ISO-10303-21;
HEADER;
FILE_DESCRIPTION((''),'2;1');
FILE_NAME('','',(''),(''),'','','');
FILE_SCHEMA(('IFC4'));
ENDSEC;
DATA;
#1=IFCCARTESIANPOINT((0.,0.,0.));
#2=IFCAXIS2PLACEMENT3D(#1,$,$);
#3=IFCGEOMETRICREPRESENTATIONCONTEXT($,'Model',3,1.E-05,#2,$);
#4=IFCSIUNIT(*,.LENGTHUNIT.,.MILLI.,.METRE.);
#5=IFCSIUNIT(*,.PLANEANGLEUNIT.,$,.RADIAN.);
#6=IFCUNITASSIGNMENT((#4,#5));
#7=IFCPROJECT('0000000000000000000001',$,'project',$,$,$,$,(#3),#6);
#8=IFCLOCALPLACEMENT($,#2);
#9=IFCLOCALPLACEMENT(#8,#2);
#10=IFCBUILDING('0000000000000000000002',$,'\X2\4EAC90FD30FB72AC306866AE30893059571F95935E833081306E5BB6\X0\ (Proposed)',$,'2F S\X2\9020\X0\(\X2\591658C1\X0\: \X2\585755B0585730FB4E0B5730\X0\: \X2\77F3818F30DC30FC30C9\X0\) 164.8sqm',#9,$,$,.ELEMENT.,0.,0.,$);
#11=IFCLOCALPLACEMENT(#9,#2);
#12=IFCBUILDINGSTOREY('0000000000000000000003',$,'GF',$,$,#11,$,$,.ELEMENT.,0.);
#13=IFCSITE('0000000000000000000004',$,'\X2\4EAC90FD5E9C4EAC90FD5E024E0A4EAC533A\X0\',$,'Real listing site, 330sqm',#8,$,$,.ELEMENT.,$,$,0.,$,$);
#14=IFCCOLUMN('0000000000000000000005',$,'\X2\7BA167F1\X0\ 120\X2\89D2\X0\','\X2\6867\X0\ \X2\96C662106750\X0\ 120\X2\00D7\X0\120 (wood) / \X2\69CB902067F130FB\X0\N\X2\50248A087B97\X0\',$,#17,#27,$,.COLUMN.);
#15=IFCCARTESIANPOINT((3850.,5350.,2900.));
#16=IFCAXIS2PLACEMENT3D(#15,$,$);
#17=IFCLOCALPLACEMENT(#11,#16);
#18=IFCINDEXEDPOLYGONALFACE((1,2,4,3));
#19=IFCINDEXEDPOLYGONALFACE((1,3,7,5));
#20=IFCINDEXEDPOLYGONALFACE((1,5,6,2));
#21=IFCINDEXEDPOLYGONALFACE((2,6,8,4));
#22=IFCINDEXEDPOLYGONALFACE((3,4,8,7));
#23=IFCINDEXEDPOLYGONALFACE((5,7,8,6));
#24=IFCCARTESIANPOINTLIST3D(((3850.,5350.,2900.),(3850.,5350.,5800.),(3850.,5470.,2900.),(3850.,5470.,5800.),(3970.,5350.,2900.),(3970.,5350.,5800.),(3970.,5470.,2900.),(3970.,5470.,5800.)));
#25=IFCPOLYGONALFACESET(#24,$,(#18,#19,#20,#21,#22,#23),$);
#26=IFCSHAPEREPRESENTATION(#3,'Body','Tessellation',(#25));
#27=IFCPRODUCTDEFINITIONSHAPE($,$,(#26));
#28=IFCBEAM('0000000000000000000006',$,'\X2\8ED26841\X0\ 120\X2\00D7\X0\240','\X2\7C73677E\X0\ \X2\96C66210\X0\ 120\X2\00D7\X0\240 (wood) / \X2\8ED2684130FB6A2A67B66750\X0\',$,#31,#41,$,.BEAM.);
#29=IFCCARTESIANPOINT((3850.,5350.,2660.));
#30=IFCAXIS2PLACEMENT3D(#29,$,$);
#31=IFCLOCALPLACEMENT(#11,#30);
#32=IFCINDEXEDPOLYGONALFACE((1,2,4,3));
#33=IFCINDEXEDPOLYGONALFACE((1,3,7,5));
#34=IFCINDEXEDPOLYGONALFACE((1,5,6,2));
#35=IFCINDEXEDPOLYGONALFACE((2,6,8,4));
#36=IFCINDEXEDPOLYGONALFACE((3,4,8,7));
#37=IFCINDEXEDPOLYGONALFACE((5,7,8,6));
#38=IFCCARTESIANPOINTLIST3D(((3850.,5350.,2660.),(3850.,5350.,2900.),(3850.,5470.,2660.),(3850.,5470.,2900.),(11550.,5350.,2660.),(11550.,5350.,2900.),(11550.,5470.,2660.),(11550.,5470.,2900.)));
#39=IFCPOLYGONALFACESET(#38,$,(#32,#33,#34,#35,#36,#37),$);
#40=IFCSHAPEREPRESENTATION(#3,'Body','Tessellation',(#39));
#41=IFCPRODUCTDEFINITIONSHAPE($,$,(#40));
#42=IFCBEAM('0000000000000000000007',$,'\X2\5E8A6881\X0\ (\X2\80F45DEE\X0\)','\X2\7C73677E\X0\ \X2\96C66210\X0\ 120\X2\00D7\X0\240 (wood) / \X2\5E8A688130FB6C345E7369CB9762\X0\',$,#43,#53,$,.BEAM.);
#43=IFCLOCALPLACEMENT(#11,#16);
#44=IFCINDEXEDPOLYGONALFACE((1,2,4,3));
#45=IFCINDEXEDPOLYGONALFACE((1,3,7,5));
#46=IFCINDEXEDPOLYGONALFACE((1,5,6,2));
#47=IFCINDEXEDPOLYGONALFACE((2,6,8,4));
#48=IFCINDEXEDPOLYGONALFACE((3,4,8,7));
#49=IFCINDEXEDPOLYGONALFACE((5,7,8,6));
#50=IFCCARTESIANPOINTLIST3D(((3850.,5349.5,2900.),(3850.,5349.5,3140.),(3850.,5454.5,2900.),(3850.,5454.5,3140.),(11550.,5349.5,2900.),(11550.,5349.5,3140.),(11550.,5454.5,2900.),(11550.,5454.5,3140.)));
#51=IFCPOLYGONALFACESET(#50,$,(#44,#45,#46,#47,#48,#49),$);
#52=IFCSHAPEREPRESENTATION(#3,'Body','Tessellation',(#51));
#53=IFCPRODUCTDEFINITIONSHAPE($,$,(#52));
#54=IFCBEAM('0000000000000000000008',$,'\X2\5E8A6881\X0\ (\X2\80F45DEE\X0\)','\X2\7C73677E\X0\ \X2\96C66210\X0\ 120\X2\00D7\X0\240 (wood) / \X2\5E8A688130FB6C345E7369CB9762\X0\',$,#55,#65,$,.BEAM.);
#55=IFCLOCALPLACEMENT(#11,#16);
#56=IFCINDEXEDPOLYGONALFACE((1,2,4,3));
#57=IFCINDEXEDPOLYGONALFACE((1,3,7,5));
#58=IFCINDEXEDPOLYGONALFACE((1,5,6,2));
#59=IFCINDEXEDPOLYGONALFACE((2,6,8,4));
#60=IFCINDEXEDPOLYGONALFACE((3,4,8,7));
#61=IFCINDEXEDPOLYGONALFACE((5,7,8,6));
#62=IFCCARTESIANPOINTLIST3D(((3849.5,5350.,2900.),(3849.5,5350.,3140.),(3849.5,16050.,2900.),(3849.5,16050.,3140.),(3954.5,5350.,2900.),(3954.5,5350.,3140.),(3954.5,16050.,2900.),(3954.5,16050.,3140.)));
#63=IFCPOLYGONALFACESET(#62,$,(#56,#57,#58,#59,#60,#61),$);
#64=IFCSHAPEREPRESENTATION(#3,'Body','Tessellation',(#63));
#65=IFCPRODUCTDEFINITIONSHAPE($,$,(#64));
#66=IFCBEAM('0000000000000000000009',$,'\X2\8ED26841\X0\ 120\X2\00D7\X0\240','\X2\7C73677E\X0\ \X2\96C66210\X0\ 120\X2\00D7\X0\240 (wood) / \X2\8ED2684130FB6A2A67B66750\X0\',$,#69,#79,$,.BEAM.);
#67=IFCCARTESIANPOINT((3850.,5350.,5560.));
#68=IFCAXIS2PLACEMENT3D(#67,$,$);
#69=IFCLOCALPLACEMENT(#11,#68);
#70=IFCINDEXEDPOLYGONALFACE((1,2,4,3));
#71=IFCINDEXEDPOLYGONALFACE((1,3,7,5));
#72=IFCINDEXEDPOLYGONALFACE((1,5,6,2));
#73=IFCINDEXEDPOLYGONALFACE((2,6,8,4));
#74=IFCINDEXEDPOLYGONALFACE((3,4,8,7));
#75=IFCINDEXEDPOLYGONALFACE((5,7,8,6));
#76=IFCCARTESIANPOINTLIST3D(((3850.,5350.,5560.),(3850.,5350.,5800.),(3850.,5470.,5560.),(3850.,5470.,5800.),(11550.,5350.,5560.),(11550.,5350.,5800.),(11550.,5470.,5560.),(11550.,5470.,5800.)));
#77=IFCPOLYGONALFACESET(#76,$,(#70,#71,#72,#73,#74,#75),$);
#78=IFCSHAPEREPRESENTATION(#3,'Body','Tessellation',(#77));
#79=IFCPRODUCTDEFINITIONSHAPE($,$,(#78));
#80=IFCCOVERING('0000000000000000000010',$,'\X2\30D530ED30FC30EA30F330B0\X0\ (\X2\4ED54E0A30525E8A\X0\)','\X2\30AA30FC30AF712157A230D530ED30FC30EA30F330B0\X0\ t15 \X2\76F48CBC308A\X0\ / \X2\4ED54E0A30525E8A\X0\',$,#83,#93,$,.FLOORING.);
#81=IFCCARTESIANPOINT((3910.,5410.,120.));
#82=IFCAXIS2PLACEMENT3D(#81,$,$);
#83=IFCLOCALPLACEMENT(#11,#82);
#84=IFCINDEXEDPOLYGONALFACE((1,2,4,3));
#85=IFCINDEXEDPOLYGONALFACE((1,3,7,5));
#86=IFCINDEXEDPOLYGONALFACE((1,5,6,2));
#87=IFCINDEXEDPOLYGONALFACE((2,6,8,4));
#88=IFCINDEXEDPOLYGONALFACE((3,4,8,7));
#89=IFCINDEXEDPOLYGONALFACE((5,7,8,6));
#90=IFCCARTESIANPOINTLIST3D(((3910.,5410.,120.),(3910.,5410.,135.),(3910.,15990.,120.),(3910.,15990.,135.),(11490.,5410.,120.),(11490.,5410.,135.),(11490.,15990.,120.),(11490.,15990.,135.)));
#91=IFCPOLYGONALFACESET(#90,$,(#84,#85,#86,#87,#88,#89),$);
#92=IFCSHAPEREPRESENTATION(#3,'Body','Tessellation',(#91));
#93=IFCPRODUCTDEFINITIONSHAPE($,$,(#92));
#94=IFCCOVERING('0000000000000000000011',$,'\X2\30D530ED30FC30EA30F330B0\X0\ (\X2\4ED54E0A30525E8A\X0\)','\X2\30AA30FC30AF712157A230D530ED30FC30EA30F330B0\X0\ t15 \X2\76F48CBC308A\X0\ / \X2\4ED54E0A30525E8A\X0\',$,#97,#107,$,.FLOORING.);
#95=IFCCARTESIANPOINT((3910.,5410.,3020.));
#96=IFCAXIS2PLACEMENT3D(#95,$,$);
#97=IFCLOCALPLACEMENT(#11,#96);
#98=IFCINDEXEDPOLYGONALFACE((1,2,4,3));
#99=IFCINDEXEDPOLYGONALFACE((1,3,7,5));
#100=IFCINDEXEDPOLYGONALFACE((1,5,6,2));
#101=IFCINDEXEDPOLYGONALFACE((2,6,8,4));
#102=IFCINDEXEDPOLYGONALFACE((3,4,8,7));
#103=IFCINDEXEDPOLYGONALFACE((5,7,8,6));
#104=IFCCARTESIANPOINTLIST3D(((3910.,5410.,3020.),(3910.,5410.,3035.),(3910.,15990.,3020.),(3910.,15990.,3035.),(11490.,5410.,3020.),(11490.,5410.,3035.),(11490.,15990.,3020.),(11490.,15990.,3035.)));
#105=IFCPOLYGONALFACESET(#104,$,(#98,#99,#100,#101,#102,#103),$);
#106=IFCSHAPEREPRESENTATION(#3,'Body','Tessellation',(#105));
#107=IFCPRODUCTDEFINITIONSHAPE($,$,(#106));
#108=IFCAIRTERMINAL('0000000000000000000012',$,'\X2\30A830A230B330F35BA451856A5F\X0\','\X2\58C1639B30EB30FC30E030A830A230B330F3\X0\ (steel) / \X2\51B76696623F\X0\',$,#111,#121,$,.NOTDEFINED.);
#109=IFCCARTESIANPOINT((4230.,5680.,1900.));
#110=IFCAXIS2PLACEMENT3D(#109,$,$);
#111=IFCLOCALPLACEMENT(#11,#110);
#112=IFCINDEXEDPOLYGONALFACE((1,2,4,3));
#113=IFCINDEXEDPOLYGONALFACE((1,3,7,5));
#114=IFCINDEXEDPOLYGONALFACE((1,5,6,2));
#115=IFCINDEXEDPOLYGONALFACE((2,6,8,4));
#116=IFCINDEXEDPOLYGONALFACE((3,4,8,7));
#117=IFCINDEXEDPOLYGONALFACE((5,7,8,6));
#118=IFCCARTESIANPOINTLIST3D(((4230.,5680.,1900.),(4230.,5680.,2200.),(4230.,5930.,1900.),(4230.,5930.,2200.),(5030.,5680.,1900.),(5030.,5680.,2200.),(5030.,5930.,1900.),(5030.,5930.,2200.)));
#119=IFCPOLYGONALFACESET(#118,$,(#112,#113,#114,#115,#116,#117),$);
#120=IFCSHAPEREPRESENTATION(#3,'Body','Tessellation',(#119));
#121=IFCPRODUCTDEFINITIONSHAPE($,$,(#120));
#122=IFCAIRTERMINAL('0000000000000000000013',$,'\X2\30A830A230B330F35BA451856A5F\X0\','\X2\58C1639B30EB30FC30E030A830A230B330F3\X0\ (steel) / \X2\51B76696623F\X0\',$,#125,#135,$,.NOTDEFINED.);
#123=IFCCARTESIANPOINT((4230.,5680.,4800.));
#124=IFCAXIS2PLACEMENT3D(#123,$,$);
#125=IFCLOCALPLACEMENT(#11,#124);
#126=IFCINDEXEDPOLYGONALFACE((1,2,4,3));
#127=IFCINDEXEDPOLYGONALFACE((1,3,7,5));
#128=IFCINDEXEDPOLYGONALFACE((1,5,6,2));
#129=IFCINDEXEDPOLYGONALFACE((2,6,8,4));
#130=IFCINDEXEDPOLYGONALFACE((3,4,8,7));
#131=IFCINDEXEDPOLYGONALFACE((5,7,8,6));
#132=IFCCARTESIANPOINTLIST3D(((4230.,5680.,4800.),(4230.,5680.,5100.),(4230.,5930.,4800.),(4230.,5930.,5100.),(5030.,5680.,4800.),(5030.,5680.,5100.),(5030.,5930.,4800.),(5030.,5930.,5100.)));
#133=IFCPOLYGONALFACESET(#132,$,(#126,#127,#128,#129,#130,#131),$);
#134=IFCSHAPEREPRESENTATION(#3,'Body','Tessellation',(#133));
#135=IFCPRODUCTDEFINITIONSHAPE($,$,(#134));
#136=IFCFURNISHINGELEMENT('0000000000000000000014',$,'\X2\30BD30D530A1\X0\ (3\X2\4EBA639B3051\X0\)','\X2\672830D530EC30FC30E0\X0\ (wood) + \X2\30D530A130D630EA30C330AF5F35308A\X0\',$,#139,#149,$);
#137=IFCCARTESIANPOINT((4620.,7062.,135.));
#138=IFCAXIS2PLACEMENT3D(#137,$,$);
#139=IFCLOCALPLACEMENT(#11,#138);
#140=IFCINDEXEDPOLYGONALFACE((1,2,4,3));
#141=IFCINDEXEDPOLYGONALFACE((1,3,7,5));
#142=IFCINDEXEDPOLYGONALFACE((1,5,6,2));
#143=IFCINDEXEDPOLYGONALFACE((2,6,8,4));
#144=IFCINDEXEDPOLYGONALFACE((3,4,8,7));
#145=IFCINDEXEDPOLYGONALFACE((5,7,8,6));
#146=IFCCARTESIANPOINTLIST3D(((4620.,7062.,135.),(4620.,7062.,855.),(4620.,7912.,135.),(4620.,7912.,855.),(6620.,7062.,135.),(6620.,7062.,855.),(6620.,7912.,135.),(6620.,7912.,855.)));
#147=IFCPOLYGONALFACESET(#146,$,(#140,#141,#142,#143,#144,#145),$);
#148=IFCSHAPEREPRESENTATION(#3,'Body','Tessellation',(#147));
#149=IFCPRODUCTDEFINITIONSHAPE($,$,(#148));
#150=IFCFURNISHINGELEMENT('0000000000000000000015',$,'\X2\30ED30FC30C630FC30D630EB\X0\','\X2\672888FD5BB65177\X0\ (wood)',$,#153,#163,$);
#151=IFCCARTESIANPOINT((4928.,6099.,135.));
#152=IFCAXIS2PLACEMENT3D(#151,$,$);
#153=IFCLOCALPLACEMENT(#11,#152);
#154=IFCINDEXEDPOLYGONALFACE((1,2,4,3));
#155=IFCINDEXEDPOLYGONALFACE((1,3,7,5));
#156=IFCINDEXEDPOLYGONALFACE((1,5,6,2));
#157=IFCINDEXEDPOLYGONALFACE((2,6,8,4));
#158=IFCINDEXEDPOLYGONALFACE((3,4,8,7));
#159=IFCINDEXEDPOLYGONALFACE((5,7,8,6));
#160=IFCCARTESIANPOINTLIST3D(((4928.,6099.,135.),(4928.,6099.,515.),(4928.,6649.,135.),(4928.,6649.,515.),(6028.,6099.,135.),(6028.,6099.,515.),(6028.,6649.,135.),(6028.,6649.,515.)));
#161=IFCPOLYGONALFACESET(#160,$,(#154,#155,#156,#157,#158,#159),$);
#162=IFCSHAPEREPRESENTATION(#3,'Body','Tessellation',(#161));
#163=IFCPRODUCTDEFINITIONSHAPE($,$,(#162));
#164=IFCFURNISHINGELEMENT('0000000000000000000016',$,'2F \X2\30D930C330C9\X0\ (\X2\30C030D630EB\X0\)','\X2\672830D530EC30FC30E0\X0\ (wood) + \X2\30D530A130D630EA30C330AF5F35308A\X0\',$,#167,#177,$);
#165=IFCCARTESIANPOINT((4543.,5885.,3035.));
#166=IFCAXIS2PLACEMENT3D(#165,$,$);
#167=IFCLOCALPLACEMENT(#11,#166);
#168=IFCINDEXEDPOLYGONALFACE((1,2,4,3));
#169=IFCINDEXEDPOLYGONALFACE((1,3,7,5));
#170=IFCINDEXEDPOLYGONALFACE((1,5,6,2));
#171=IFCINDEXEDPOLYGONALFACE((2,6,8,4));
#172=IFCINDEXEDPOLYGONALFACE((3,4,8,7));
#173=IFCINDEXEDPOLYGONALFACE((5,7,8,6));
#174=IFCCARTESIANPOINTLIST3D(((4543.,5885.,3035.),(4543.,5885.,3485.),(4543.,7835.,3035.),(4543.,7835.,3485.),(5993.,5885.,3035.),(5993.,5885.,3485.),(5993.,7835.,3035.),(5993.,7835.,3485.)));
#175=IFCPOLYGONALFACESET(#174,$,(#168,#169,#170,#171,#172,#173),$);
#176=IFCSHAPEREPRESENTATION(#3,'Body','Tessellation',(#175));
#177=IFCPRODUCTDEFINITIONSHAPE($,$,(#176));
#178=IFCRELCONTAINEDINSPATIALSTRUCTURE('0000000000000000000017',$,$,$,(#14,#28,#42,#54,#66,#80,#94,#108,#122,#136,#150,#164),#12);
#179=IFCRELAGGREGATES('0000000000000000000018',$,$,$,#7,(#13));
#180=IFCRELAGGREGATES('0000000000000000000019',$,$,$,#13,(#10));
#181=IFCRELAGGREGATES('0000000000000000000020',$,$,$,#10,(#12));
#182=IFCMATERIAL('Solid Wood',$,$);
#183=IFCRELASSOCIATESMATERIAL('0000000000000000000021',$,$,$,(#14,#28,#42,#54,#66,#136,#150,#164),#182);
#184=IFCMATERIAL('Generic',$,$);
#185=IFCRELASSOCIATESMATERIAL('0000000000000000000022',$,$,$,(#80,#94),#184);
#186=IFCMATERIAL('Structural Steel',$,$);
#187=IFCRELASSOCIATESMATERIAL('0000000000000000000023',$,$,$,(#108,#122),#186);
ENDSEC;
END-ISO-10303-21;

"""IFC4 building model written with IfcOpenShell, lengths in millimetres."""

from ifc_helpers import new_model, si_unit, frame, frame_2d, origin, place, context, project, spatial, rectangle, extrude, material, element, save


model = new_model("IFC4")

# Units and contexts
model_context = context("Model", 3, precision=1e-05, world=origin())
ifc_project = project(units=[si_unit("LENGTHUNIT", "METRE", prefix="MILLI"), si_unit("PLANEANGLEUNIT", "RADIAN")], contexts=[model_context])

# Site, building, storey
site_placement = place(None, origin())
site = spatial("IfcSite", under=ifc_project, at=site_placement, Name="京都府京都市上京区", ObjectType="Real listing site, 330sqm", CompositionType="ELEMENT", RefElevation=0.0)
building_placement = place(site_placement, origin())
building = spatial("IfcBuilding", under=site, at=building_placement, Name="京都・犬と暮らす土間広めの家 (Proposed)", ObjectType="2F S造(外壁: 塗喰塗・下地: 石膏ボード) 164.8sqm", CompositionType="ELEMENT", ElevationOfRefHeight=0.0, ElevationOfTerrain=0.0)
storey_placement = place(building_placement, origin())
storey = spatial("IfcBuildingStorey", under=building, at=storey_placement, Name="GF", CompositionType="ELEMENT", Elevation=0.0)

# Column
ifc_material_1 = material(Name="Solid Wood")
column_1_placement = place(storey_placement, frame((3850.0, 5350.0, 2900.0)))
element("IfcColumn", 1, at=column_1_placement, inside=storey, material=ifc_material_1, Name="管柱 120角", Description="桧 集成材 120×120 (wood) / 構造柱・N値計算", PredefinedType="COLUMN", context=model_context, shape_type="SweptSolid", body=[
    extrude(rectangle(XDim=120.0, YDim=120.0, at=frame_2d((60.0, 60.0))), frame((3850.0, 5350.0, 2900.0)), (0.0, 0.0, 1.0), 2900.0),
])

# Beams
beam_1_placement = place(storey_placement, frame((3850.0, 5350.0, 2660.0)))
element("IfcBeam", 2, at=beam_1_placement, inside=storey, material=ifc_material_1, Name="軒桁 120×240", Description="米松 集成 120×240 (wood) / 軒桁・横架材", PredefinedType="BEAM", context=model_context, shape_type="SweptSolid", body=[
    extrude(rectangle(XDim=7700.0, YDim=120.0, at=frame_2d((3850.0, 60.0))), frame((3850.0, 5350.0, 2660.0)), (0.0, 0.0, 1.0), 240.0),
])
beam_2_placement = place(storey_placement, frame((3850.0, 5350.0, 2900.0)))
element("IfcBeam", 3, at=beam_2_placement, inside=storey, material=ifc_material_1, Name="床梁 (胴差)", Description="米松 集成 120×240 (wood) / 床梁・水平構面", PredefinedType="BEAM", context=model_context, shape_type="SweptSolid", body=[
    extrude(rectangle(XDim=7700.0, YDim=105.0, at=frame_2d((3850.0, 52.0))), frame((3850.0, 5350.0, 2900.0)), (0.0, 0.0, 1.0), 240.0),
])
beam_3_placement = place(storey_placement, frame((3850.0, 5350.0, 2900.0)))
element("IfcBeam", 4, at=beam_3_placement, inside=storey, material=ifc_material_1, Name="床梁 (胴差)", Description="米松 集成 120×240 (wood) / 床梁・水平構面", PredefinedType="BEAM", context=model_context, shape_type="SweptSolid", body=[
    extrude(rectangle(XDim=105.0, YDim=10700.0, at=frame_2d((52.0, 5350.0))), frame((3850.0, 5350.0, 2900.0)), (0.0, 0.0, 1.0), 240.0),
])
beam_4_placement = place(storey_placement, frame((3850.0, 5350.0, 5560.0)))
element("IfcBeam", 5, at=beam_4_placement, inside=storey, material=ifc_material_1, Name="軒桁 120×240", Description="米松 集成 120×240 (wood) / 軒桁・横架材", PredefinedType="BEAM", context=model_context, shape_type="SweptSolid", body=[
    extrude(rectangle(XDim=7700.0, YDim=120.0, at=frame_2d((3850.0, 60.0))), frame((3850.0, 5350.0, 5560.0)), (0.0, 0.0, 1.0), 240.0),
])

# Coverings
ifc_material_2 = material(Name="Generic")
covering_1_placement = place(storey_placement, frame((3910.0, 5410.0, 120.0)))
element("IfcCovering", 6, at=covering_1_placement, inside=storey, material=ifc_material_2, Name="フローリング (仕上げ床)", Description="オーク無垢フローリング t15 直貼り / 仕上げ床", PredefinedType="FLOORING", context=model_context, shape_type="SweptSolid", body=[
    extrude(rectangle(XDim=7580.0, YDim=10580.0, at=frame_2d((3790.0, 5290.0))), frame((3910.0, 5410.0, 120.0)), (0.0, 0.0, 1.0), 15.0),
])
covering_2_placement = place(storey_placement, frame((3910.0, 5410.0, 3020.0)))
element("IfcCovering", 7, at=covering_2_placement, inside=storey, material=ifc_material_2, Name="フローリング (仕上げ床)", Description="オーク無垢フローリング t15 直貼り / 仕上げ床", PredefinedType="FLOORING", context=model_context, shape_type="SweptSolid", body=[
    extrude(rectangle(XDim=7580.0, YDim=10580.0, at=frame_2d((3790.0, 5290.0))), frame((3910.0, 5410.0, 3020.0)), (0.0, 0.0, 1.0), 15.0),
])

# Air terminals
ifc_material_3 = material(Name="Structural Steel")
air_terminal_1_placement = place(storey_placement, frame((4230.0, 5680.0, 1900.0)))
element("IfcAirTerminal", 8, at=air_terminal_1_placement, inside=storey, material=ifc_material_3, Name="エアコン室内機", Description="壁掛ルームエアコン (steel) / 冷暖房", PredefinedType="NOTDEFINED", context=model_context, shape_type="SweptSolid", body=[
    extrude(rectangle(XDim=800.0, YDim=250.0, at=frame_2d((400.0, 125.0))), frame((4230.0, 5680.0, 1900.0)), (0.0, 0.0, 1.0), 300.0),
])
air_terminal_2_placement = place(storey_placement, frame((4230.0, 5680.0, 4800.0)))
element("IfcAirTerminal", 9, at=air_terminal_2_placement, inside=storey, material=ifc_material_3, Name="エアコン室内機", Description="壁掛ルームエアコン (steel) / 冷暖房", PredefinedType="NOTDEFINED", context=model_context, shape_type="SweptSolid", body=[
    extrude(rectangle(XDim=800.0, YDim=250.0, at=frame_2d((400.0, 125.0))), frame((4230.0, 5680.0, 4800.0)), (0.0, 0.0, 1.0), 300.0),
])

# Furnishing elements
furnishing_1_placement = place(storey_placement, frame((4620.0, 7062.0, 135.0)))
element("IfcFurnishingElement", 10, at=furnishing_1_placement, inside=storey, material=ifc_material_1, Name="ソファ (3人掛け)", Description="木フレーム (wood) + ファブリック張り", context=model_context, shape_type="SweptSolid", body=[
    extrude(rectangle(XDim=2000.0, YDim=850.0, at=frame_2d((1000.0, 425.0))), frame((4620.0, 7062.0, 135.0)), (0.0, 0.0, 1.0), 720.0),
])
furnishing_2_placement = place(storey_placement, frame((4928.0, 6099.0, 135.0)))
element("IfcFurnishingElement", 11, at=furnishing_2_placement, inside=storey, material=ifc_material_1, Name="ローテーブル", Description="木製家具 (wood)", context=model_context, shape_type="SweptSolid", body=[
    extrude(rectangle(XDim=1100.0, YDim=550.0, at=frame_2d((550.0, 275.0))), frame((4928.0, 6099.0, 135.0)), (0.0, 0.0, 1.0), 380.0),
])
furnishing_3_placement = place(storey_placement, frame((4543.0, 5885.0, 3035.0)))
element("IfcFurnishingElement", 12, at=furnishing_3_placement, inside=storey, material=ifc_material_1, Name="2F ベッド (ダブル)", Description="木フレーム (wood) + ファブリック張り", context=model_context, shape_type="SweptSolid", body=[
    extrude(rectangle(XDim=1450.0, YDim=1950.0, at=frame_2d((725.0, 975.0))), frame((4543.0, 5885.0, 3035.0)), (0.0, 0.0, 1.0), 450.0),
])

save(model, "model.ifc")
